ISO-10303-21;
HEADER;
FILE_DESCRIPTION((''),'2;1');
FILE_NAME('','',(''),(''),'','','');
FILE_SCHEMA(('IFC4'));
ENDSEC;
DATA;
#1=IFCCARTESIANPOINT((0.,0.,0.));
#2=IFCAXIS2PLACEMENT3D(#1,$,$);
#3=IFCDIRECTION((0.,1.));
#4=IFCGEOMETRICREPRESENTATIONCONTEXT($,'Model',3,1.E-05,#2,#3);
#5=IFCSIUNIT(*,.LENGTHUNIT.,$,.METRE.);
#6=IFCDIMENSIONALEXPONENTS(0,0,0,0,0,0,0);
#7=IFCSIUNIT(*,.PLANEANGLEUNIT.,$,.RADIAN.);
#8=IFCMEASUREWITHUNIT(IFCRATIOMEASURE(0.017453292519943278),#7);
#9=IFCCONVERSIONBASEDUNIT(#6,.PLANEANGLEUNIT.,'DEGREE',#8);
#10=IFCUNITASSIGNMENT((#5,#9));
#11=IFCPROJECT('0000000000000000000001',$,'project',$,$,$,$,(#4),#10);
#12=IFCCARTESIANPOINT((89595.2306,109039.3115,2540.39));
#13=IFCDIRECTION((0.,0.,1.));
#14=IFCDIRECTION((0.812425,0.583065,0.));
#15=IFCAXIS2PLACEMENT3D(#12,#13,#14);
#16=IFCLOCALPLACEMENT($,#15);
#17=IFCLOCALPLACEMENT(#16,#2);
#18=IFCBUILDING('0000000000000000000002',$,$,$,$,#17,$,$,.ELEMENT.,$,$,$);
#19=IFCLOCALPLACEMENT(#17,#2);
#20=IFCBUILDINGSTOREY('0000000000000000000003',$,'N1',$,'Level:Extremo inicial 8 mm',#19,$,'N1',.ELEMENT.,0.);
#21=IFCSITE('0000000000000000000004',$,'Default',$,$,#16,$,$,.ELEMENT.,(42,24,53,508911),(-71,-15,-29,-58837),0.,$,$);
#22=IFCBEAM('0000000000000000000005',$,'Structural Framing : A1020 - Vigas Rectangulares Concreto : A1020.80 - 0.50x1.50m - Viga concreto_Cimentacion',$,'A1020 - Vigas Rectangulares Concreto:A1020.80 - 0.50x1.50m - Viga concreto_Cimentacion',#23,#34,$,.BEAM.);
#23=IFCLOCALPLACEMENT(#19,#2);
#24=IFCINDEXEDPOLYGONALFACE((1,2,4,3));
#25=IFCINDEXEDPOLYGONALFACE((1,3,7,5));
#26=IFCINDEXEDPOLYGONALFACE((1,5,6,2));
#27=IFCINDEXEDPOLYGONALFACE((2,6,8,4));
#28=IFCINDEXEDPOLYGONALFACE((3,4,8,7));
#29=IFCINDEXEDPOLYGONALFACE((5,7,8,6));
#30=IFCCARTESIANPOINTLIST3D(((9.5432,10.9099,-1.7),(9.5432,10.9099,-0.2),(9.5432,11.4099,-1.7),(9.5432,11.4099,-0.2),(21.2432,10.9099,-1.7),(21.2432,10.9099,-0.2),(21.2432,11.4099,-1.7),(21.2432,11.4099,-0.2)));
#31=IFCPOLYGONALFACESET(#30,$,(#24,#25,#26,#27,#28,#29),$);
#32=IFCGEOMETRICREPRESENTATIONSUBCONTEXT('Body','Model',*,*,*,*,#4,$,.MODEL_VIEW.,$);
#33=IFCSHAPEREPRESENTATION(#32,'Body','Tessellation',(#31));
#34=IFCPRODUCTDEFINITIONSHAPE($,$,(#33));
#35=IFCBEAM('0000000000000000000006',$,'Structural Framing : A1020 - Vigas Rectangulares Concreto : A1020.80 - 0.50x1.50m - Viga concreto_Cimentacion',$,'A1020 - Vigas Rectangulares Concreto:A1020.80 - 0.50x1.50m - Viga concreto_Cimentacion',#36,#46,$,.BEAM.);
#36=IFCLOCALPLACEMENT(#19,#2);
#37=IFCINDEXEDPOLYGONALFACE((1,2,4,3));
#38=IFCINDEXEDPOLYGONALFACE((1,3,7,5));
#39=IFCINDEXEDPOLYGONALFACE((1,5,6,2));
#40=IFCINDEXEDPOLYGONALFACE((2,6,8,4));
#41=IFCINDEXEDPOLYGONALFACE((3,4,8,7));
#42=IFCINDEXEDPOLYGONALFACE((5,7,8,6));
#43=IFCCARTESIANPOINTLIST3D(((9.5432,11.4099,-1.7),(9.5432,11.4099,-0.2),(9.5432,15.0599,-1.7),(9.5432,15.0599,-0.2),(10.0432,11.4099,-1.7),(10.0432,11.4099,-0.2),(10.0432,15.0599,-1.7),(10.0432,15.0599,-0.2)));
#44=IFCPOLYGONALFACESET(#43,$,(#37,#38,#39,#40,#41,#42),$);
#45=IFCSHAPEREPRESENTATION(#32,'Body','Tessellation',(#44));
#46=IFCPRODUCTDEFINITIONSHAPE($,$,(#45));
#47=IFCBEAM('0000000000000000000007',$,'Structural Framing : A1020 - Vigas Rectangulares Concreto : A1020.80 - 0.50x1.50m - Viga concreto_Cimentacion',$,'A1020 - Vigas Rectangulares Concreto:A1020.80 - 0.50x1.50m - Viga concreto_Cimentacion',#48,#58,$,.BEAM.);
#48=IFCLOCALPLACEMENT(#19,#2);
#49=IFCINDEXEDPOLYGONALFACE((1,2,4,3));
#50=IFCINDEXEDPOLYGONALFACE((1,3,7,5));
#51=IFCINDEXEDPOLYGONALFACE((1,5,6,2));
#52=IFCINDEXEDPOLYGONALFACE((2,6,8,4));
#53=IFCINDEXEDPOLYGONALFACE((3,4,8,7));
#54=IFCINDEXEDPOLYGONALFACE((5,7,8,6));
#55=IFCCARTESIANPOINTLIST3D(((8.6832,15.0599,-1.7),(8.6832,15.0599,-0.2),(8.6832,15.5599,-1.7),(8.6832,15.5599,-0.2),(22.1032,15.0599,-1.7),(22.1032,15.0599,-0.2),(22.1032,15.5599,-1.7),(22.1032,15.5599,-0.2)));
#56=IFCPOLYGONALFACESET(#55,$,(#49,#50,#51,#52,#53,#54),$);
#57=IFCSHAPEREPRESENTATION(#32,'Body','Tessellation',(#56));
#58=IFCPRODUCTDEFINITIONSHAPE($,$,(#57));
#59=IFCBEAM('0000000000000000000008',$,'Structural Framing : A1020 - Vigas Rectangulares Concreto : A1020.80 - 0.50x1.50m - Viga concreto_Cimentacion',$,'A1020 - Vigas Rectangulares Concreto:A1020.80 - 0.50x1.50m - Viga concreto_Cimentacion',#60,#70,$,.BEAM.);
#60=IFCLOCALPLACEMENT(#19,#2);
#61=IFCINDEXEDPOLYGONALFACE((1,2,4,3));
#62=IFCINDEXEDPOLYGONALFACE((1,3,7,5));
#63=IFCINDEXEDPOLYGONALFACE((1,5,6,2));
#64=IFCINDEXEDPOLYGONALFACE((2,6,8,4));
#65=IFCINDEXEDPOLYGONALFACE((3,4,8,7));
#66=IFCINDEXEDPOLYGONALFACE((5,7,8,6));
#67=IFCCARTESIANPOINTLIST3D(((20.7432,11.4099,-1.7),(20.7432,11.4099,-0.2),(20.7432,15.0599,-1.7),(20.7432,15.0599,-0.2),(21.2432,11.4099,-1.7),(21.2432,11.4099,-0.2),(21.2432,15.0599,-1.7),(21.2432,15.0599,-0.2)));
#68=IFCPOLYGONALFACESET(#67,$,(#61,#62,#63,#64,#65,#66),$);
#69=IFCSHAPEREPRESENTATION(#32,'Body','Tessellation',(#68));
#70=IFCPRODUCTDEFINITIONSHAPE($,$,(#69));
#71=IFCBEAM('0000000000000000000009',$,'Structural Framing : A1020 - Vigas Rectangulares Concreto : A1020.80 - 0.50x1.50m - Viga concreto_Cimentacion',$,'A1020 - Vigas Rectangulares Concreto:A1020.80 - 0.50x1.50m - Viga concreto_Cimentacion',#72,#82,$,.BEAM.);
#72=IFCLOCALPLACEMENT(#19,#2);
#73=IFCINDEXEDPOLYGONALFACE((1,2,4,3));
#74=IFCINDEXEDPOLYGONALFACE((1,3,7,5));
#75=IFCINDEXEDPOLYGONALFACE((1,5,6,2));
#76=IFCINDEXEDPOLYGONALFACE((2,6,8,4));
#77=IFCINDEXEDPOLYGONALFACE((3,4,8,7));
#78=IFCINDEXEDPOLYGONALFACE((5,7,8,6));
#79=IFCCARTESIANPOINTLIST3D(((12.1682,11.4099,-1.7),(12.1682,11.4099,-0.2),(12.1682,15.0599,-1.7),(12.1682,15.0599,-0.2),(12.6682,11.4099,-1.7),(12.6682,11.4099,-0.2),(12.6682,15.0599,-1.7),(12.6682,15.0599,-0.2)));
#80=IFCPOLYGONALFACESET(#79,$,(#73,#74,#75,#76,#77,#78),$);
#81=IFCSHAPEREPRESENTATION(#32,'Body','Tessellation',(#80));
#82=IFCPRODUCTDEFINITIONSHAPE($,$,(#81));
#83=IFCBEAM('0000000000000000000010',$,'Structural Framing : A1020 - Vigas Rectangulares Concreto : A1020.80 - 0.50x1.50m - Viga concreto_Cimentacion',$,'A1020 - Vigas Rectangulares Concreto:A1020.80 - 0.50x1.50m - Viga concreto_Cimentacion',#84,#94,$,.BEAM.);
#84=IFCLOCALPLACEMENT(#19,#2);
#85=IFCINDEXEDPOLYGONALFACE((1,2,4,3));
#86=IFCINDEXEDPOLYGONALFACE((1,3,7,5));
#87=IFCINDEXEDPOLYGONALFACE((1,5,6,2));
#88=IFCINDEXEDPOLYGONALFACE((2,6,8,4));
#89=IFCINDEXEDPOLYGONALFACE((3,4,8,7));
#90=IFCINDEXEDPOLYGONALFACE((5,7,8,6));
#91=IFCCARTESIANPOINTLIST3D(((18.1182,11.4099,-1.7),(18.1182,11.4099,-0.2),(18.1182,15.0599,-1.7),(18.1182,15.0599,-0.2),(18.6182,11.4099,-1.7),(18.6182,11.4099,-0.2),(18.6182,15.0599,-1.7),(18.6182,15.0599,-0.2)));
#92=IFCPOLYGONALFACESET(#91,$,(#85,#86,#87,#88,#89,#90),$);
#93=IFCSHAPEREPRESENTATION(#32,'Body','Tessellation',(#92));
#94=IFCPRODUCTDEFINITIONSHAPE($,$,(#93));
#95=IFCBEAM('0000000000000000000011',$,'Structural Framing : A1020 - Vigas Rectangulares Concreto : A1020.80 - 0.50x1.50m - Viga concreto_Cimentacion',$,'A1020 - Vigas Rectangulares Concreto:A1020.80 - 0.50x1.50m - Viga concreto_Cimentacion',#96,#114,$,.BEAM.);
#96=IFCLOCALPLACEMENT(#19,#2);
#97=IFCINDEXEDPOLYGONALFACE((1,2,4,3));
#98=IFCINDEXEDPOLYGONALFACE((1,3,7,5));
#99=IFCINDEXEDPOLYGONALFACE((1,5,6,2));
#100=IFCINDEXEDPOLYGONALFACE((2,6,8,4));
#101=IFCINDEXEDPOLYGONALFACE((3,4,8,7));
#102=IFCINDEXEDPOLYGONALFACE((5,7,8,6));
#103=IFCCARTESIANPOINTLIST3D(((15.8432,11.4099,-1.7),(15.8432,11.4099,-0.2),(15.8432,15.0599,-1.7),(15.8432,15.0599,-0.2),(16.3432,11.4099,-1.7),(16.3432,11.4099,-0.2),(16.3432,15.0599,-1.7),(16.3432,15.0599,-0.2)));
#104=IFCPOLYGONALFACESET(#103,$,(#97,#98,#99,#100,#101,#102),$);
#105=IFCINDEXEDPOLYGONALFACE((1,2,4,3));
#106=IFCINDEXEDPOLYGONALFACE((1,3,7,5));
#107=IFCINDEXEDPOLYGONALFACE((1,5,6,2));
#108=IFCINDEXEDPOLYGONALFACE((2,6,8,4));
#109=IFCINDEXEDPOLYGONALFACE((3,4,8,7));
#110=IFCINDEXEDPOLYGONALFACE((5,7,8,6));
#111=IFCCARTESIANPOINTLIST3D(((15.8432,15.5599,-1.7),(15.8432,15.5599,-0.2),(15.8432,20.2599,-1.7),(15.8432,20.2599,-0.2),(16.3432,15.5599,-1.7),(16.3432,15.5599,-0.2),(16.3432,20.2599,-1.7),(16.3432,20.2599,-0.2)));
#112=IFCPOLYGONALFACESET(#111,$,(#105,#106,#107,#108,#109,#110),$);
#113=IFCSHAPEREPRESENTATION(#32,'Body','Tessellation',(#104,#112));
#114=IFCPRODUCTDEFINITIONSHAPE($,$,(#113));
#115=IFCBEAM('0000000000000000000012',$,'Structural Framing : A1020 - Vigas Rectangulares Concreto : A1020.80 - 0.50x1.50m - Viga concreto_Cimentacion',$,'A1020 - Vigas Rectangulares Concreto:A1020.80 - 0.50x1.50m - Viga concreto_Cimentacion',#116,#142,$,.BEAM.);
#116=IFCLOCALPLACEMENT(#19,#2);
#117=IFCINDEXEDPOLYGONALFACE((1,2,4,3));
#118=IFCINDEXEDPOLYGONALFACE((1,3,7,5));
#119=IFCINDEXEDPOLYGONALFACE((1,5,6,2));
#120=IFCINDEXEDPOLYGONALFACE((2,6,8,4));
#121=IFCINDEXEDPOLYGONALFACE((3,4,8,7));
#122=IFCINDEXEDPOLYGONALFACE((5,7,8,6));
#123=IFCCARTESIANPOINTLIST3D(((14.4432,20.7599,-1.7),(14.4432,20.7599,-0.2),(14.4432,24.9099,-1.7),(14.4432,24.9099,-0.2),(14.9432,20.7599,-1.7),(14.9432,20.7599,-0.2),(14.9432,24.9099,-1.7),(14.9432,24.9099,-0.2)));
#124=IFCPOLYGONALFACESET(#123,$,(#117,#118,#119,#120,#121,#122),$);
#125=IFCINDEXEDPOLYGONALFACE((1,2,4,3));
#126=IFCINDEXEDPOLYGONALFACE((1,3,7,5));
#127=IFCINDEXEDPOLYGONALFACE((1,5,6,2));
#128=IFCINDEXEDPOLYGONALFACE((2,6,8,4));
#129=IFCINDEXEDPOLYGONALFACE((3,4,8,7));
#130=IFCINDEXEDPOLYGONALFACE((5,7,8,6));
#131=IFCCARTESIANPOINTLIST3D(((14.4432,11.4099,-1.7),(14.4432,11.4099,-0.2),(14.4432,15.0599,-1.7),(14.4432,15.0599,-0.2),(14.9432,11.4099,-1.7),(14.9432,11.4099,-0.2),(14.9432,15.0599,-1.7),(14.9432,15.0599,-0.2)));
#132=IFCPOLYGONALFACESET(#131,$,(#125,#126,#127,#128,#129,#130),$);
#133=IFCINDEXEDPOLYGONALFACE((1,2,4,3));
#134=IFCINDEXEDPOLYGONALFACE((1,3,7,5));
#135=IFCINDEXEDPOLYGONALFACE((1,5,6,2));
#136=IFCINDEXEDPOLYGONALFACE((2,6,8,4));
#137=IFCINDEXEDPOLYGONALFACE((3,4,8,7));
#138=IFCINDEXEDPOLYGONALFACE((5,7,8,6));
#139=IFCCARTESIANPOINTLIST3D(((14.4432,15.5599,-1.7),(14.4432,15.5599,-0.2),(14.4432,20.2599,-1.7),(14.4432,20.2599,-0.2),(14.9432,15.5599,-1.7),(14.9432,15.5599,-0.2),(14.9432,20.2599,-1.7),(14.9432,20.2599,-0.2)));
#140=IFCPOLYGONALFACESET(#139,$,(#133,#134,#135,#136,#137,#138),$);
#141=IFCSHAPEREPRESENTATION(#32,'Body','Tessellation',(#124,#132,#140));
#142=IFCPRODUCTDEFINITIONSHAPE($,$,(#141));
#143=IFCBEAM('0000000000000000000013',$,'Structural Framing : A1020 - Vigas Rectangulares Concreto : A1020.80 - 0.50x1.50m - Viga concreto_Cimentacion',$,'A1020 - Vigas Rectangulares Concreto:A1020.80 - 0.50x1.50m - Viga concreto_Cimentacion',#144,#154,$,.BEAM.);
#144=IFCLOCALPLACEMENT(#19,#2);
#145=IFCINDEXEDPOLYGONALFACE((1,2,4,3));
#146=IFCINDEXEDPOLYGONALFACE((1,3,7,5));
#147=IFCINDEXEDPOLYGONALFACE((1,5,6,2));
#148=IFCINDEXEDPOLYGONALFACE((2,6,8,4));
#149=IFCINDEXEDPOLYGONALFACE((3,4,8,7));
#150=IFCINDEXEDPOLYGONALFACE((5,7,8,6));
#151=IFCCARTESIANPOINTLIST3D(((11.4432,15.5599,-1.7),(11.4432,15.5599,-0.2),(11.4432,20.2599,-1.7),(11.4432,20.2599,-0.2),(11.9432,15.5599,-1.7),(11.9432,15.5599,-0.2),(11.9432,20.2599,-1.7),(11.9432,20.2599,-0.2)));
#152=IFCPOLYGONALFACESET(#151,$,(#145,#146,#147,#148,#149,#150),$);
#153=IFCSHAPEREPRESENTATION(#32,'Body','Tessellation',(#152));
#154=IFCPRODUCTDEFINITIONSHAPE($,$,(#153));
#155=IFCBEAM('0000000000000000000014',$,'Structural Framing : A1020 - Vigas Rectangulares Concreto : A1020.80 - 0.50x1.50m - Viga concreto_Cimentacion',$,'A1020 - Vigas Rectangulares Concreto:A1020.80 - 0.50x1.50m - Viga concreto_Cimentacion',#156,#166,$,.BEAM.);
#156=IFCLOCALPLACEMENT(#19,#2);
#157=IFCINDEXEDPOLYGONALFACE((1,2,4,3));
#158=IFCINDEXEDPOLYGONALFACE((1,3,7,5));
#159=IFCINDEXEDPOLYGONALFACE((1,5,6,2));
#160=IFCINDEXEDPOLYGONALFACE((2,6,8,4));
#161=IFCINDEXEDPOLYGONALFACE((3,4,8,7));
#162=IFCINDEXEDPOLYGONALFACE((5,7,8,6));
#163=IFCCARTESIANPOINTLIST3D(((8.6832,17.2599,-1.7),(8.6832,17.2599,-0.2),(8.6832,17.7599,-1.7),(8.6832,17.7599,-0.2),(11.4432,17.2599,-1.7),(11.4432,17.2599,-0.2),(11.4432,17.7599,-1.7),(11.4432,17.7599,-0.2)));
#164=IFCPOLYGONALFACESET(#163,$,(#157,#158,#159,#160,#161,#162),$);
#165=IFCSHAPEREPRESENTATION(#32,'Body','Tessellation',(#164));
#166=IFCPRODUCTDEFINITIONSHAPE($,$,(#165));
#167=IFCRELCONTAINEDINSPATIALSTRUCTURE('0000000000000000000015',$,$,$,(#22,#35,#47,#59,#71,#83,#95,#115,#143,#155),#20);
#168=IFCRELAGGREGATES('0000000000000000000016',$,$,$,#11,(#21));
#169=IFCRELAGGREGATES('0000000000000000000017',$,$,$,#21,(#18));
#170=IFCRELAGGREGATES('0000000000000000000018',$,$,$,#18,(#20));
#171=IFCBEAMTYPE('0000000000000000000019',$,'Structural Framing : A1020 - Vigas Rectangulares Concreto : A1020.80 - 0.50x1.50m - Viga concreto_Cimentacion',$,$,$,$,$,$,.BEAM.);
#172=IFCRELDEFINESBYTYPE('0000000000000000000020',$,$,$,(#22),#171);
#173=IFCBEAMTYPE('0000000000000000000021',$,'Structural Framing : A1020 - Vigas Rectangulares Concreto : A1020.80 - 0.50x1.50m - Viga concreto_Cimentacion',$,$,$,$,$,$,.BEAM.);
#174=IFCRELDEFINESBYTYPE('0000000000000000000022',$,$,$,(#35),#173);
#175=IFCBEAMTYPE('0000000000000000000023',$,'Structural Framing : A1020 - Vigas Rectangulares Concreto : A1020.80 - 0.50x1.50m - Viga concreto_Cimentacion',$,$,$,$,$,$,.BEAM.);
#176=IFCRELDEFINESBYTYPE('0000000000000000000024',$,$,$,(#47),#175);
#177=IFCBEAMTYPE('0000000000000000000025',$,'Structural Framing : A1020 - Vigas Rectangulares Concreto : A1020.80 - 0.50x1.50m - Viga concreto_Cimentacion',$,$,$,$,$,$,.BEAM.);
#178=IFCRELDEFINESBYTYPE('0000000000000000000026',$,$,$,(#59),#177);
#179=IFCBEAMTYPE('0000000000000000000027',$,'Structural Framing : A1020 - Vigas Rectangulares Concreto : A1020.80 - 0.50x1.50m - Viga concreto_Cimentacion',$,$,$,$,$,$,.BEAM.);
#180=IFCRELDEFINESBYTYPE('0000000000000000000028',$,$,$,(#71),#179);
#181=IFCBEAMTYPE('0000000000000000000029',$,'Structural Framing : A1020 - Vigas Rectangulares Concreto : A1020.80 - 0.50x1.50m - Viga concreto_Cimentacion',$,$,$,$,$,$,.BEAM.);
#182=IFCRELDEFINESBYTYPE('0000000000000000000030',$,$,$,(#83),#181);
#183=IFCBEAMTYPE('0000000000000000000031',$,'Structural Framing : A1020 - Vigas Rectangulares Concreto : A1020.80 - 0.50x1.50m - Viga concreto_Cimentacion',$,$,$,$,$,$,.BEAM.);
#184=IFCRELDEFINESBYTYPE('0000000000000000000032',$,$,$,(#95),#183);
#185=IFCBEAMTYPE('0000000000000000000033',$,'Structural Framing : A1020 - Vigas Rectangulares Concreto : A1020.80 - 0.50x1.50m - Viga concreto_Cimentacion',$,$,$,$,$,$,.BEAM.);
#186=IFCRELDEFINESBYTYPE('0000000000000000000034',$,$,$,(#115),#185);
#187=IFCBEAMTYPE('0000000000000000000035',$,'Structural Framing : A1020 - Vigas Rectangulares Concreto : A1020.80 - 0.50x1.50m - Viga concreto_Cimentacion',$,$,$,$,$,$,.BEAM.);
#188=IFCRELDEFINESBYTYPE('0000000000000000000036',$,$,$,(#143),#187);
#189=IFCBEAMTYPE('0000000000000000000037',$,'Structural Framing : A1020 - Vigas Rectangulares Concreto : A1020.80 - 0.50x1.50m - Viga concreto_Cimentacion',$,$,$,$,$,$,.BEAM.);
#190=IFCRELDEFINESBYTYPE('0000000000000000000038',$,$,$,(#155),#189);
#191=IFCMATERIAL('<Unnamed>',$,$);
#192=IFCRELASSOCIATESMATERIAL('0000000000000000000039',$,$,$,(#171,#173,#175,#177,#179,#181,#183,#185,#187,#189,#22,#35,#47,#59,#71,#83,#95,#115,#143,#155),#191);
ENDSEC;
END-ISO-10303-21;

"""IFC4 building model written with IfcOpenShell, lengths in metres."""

from ifc_helpers import new_model, entity, si_unit, converted_unit, direction, frame, frame_2d, origin, place, context, subcontext, project, spatial, polyline, segment, composite_curve, rectangle, outline, extrude, source, transform, mapped, material, material_profile, profile_set, profile_usage, type_object, type_shapes, element, save


model = new_model("IFC4")

# Units and contexts
model_context = context("Model", 3, precision=1e-05, world=origin(), true_north=direction((0.0, 1.0)))
body_context = subcontext(model_context, "Body", "Model", "MODEL_VIEW")
ifc_project = project(units=[si_unit("LENGTHUNIT", "METRE"), converted_unit("PLANEANGLEUNIT", "DEGREE", entity("IfcRatioMeasure", 0.017453292519943278), si_unit("PLANEANGLEUNIT", "RADIAN"), dimensions=[0, 0, 0, 0, 0, 0, 0])], contexts=[model_context])

# Site, building, storey
site_placement = place(None, frame((89595.2306, 109039.3115, 2540.39), z_axis=(0.0, 0.0, 1.0), x_axis=(0.812425, 0.583065, 0.0)))
site = spatial("IfcSite", under=ifc_project, at=site_placement, Name="Default", CompositionType="ELEMENT", RefLatitude=(42, 24, 53, 508911), RefLongitude=(-71, -15, -29, -58837), RefElevation=0.0)
building_placement = place(site_placement, origin())
building = spatial("IfcBuilding", under=site, at=building_placement, CompositionType="ELEMENT")
storey_placement = place(building_placement, origin())
storey = spatial("IfcBuildingStorey", under=building, at=storey_placement, Name="N1", ObjectType="Level:Extremo inicial 8 mm", LongName="N1", CompositionType="ELEMENT", Elevation=0.0)

# Beams
ifc_material_1 = material(Name="<Unnamed>")
ifc_material_profile_1 = material_profile(ifc_material_1, outline(composite_curve([segment(polyline([(0.25, 0.75, 0.0), (0.25, -0.75, 0.0)]), True, "CONTINUOUS"), segment(polyline([(0.25, -0.75, 0.0), (-0.25, -0.75, 0.0)]), True, "CONTINUOUS"), segment(polyline([(-0.25, -0.75, 0.0), (-0.25, 0.75, 0.0)]), True, "CONTINUOUS"), segment(polyline([(-0.25, 0.75, 0.0), (0.25, 0.75, 0.0)]), True, "CONTINUOUS")], self_intersect=False), kind="CURVE"), Name="A1020.80 - 0.50x1.50m - Viga concreto_Cimentacion")
ifc_material_profile_2 = material_profile(ifc_material_1, outline(composite_curve([segment(polyline([(-5.3373, 0.25, 0.75), (-5.3373, 0.25, -0.75)]), True, "CONTINUOUS"), segment(polyline([(-5.3373, 0.25, -0.75), (-5.3373, -0.25, -0.75)]), True, "CONTINUOUS"), segment(polyline([(-5.3373, -0.25, -0.75), (-5.3373, -0.25, 0.75)]), True, "CONTINUOUS"), segment(polyline([(-5.3373, -0.25, 0.75), (-5.3373, 0.25, 0.75)]), True, "CONTINUOUS")], self_intersect=False), kind="CURVE"), Name="A1020.80 - 0.50x1.50m - Viga concreto_Cimentacion")
ifc_profile_set_1 = profile_set([ifc_material_profile_1, ifc_material_profile_2], Name="A1020.80 - 0.50x1.50m - Viga concreto_Cimentacion")
ifc_profile_usage_1 = profile_usage(ifc_profile_set_1, cardinal=8)
beam_type_1 = type_object("IfcBeamType", Name="Structural Framing : A1020 - Vigas Rectangulares Concreto : A1020.80 - 0.50x1.50m - Viga concreto_Cimentacion", PredefinedType="BEAM", material=ifc_profile_set_1)
shared_shape_1 = source(origin(), body_context, "Body", "SweptSolid", [
    extrude(rectangle(XDim=1.5, YDim=0.5, at=frame_2d((0.0, 0.0), x_axis=(1.0, 0.0))), frame((9.5432, 11.1599, -0.95), z_axis=(1.0, 0.0, 0.0), x_axis=(0.0, 0.0, -1.0)), (0.0, 0.0, 1.0), 11.7),
])
type_shapes(beam_type_1, [shared_shape_1])
beam_1_placement = place(storey_placement, origin())
element("IfcBeam", 1, at=beam_1_placement, inside=storey, type_object=beam_type_1, material=ifc_profile_usage_1, Name="Structural Framing : A1020 - Vigas Rectangulares Concreto : A1020.80 - 0.50x1.50m - Viga concreto_Cimentacion", ObjectType="A1020 - Vigas Rectangulares Concreto:A1020.80 - 0.50x1.50m - Viga concreto_Cimentacion", PredefinedType="BEAM", context=body_context, shape_type="MappedRepresentation", body=[
    mapped(shared_shape_1, transform((0.0, 0.0, 0.0), scale=1.0)),
])
ifc_profile_usage_2 = profile_usage(ifc_profile_set_1, cardinal=8)
beam_type_2 = type_object("IfcBeamType", Name="Structural Framing : A1020 - Vigas Rectangulares Concreto : A1020.80 - 0.50x1.50m - Viga concreto_Cimentacion", PredefinedType="BEAM", material=ifc_profile_set_1)
shared_shape_2 = source(origin(), body_context, "Body", "SweptSolid", [
    extrude(rectangle(XDim=1.5, YDim=0.5, at=frame_2d((0.0, 0.0), x_axis=(0.0, 1.0))), frame((9.7932, 11.4099, -0.95), z_axis=(0.0, 1.0, 0.0), x_axis=(-1.0, 0.0, 0.0)), (0.0, 0.0, 1.0), 3.65),
])
type_shapes(beam_type_2, [shared_shape_2])
beam_2_placement = place(storey_placement, origin())
element("IfcBeam", 2, at=beam_2_placement, inside=storey, type_object=beam_type_2, material=ifc_profile_usage_2, Name="Structural Framing : A1020 - Vigas Rectangulares Concreto : A1020.80 - 0.50x1.50m - Viga concreto_Cimentacion", ObjectType="A1020 - Vigas Rectangulares Concreto:A1020.80 - 0.50x1.50m - Viga concreto_Cimentacion", PredefinedType="BEAM", context=body_context, shape_type="MappedRepresentation", body=[
    mapped(shared_shape_2, transform((0.0, 0.0, 0.0), scale=1.0)),
])
ifc_profile_usage_3 = profile_usage(ifc_profile_set_1, cardinal=8)
beam_type_3 = type_object("IfcBeamType", Name="Structural Framing : A1020 - Vigas Rectangulares Concreto : A1020.80 - 0.50x1.50m - Viga concreto_Cimentacion", PredefinedType="BEAM", material=ifc_profile_set_1)
shared_shape_3 = source(origin(), body_context, "Body", "SweptSolid", [
    extrude(rectangle(XDim=1.5, YDim=0.5, at=frame_2d((0.0, 0.0), x_axis=(1.0, 0.0))), frame((22.1032, 15.3099, -0.95), z_axis=(-1.0, 0.0, 0.0), x_axis=(0.0, 0.0, -1.0)), (0.0, 0.0, 1.0), 13.42),
])
type_shapes(beam_type_3, [shared_shape_3])
beam_3_placement = place(storey_placement, origin())
element("IfcBeam", 3, at=beam_3_placement, inside=storey, type_object=beam_type_3, material=ifc_profile_usage_3, Name="Structural Framing : A1020 - Vigas Rectangulares Concreto : A1020.80 - 0.50x1.50m - Viga concreto_Cimentacion", ObjectType="A1020 - Vigas Rectangulares Concreto:A1020.80 - 0.50x1.50m - Viga concreto_Cimentacion", PredefinedType="BEAM", context=body_context, shape_type="MappedRepresentation", body=[
    mapped(shared_shape_3, transform((0.0, 0.0, 0.0), scale=1.0)),
])
ifc_profile_usage_4 = profile_usage(ifc_profile_set_1, cardinal=8)
beam_type_4 = type_object("IfcBeamType", Name="Structural Framing : A1020 - Vigas Rectangulares Concreto : A1020.80 - 0.50x1.50m - Viga concreto_Cimentacion", PredefinedType="BEAM", material=ifc_profile_set_1)
shared_shape_4 = source(origin(), body_context, "Body", "SweptSolid", [
    extrude(rectangle(XDim=1.5, YDim=0.5, at=frame_2d((0.0, 0.0), x_axis=(0.0, 1.0))), frame((20.9932, 11.4099, -0.95), z_axis=(0.0, 1.0, 0.0), x_axis=(-1.0, 0.0, 0.0)), (0.0, 0.0, 1.0), 3.65),
])
type_shapes(beam_type_4, [shared_shape_4])
beam_4_placement = place(storey_placement, origin())
element("IfcBeam", 4, at=beam_4_placement, inside=storey, type_object=beam_type_4, material=ifc_profile_usage_4, Name="Structural Framing : A1020 - Vigas Rectangulares Concreto : A1020.80 - 0.50x1.50m - Viga concreto_Cimentacion", ObjectType="A1020 - Vigas Rectangulares Concreto:A1020.80 - 0.50x1.50m - Viga concreto_Cimentacion", PredefinedType="BEAM", context=body_context, shape_type="MappedRepresentation", body=[
    mapped(shared_shape_4, transform((0.0, 0.0, 0.0), scale=1.0)),
])
ifc_profile_usage_5 = profile_usage(ifc_profile_set_1, cardinal=8)
beam_type_5 = type_object("IfcBeamType", Name="Structural Framing : A1020 - Vigas Rectangulares Concreto : A1020.80 - 0.50x1.50m - Viga concreto_Cimentacion", PredefinedType="BEAM", material=ifc_profile_set_1)
shared_shape_5 = source(origin(), body_context, "Body", "SweptSolid", [
    extrude(rectangle(XDim=1.5, YDim=0.5, at=frame_2d((0.0, 0.0), x_axis=(0.0, 1.0))), frame((12.4182, 11.4099, -0.95), z_axis=(0.0, 1.0, 0.0), x_axis=(-1.0, 0.0, 0.0)), (0.0, 0.0, 1.0), 3.65),
])
type_shapes(beam_type_5, [shared_shape_5])
beam_5_placement = place(storey_placement, origin())
element("IfcBeam", 5, at=beam_5_placement, inside=storey, type_object=beam_type_5, material=ifc_profile_usage_5, Name="Structural Framing : A1020 - Vigas Rectangulares Concreto : A1020.80 - 0.50x1.50m - Viga concreto_Cimentacion", ObjectType="A1020 - Vigas Rectangulares Concreto:A1020.80 - 0.50x1.50m - Viga concreto_Cimentacion", PredefinedType="BEAM", context=body_context, shape_type="MappedRepresentation", body=[
    mapped(shared_shape_5, transform((0.0, 0.0, 0.0), scale=1.0)),
])
ifc_profile_usage_6 = profile_usage(ifc_profile_set_1, cardinal=8)
beam_type_6 = type_object("IfcBeamType", Name="Structural Framing : A1020 - Vigas Rectangulares Concreto : A1020.80 - 0.50x1.50m - Viga concreto_Cimentacion", PredefinedType="BEAM", material=ifc_profile_set_1)
shared_shape_6 = source(origin(), body_context, "Body", "SweptSolid", [
    extrude(rectangle(XDim=1.5, YDim=0.5, at=frame_2d((0.0, 0.0), x_axis=(0.0, 1.0))), frame((18.3682, 11.4099, -0.95), z_axis=(0.0, 1.0, 0.0), x_axis=(-1.0, 0.0, 0.0)), (0.0, 0.0, 1.0), 3.65),
])
type_shapes(beam_type_6, [shared_shape_6])
beam_6_placement = place(storey_placement, origin())
element("IfcBeam", 6, at=beam_6_placement, inside=storey, type_object=beam_type_6, material=ifc_profile_usage_6, Name="Structural Framing : A1020 - Vigas Rectangulares Concreto : A1020.80 - 0.50x1.50m - Viga concreto_Cimentacion", ObjectType="A1020 - Vigas Rectangulares Concreto:A1020.80 - 0.50x1.50m - Viga concreto_Cimentacion", PredefinedType="BEAM", context=body_context, shape_type="MappedRepresentation", body=[
    mapped(shared_shape_6, transform((0.0, 0.0, 0.0), scale=1.0)),
])
ifc_profile_usage_7 = profile_usage(ifc_profile_set_1, cardinal=8)
beam_type_7 = type_object("IfcBeamType", Name="Structural Framing : A1020 - Vigas Rectangulares Concreto : A1020.80 - 0.50x1.50m - Viga concreto_Cimentacion", PredefinedType="BEAM", material=ifc_profile_set_1)
shared_shape_7 = source(origin(), body_context, "Body", "SweptSolid", [
    extrude(rectangle(XDim=1.5, YDim=0.5, at=frame_2d((0.0, 0.0), x_axis=(0.0, 1.0))), frame((16.0932, 11.4099, -0.95), z_axis=(0.0, 1.0, 0.0), x_axis=(-1.0, 0.0, 0.0)), (0.0, 0.0, 1.0), 3.65),
    extrude(rectangle(XDim=1.5, YDim=0.5, at=frame_2d((0.0, 0.0), x_axis=(0.0, 1.0))), frame((16.0932, 15.5599, -0.95), z_axis=(0.0, 1.0, 0.0), x_axis=(-1.0, 0.0, 0.0)), (0.0, 0.0, 1.0), 4.7),
])
type_shapes(beam_type_7, [shared_shape_7])
beam_7_placement = place(storey_placement, origin())
element("IfcBeam", 7, at=beam_7_placement, inside=storey, type_object=beam_type_7, material=ifc_profile_usage_7, Name="Structural Framing : A1020 - Vigas Rectangulares Concreto : A1020.80 - 0.50x1.50m - Viga concreto_Cimentacion", ObjectType="A1020 - Vigas Rectangulares Concreto:A1020.80 - 0.50x1.50m - Viga concreto_Cimentacion", PredefinedType="BEAM", context=body_context, shape_type="MappedRepresentation", body=[
    mapped(shared_shape_7, transform((0.0, 0.0, 0.0), scale=1.0)),
])
ifc_profile_usage_8 = profile_usage(ifc_profile_set_1, cardinal=8)
beam_type_8 = type_object("IfcBeamType", Name="Structural Framing : A1020 - Vigas Rectangulares Concreto : A1020.80 - 0.50x1.50m - Viga concreto_Cimentacion", PredefinedType="BEAM", material=ifc_profile_set_1)
shared_shape_8 = source(origin(), body_context, "Body", "SweptSolid", [
    extrude(rectangle(XDim=1.5, YDim=0.5, at=frame_2d((0.0, 0.0), x_axis=(0.0, 1.0))), frame((14.6932, 20.7599, -0.95), z_axis=(0.0, 1.0, 0.0), x_axis=(-1.0, 0.0, 0.0)), (0.0, 0.0, 1.0), 4.15),
    extrude(rectangle(XDim=1.5, YDim=0.5, at=frame_2d((0.0, 0.0), x_axis=(0.0, 1.0))), frame((14.6932, 11.4099, -0.95), z_axis=(0.0, 1.0, 0.0), x_axis=(-1.0, 0.0, 0.0)), (0.0, 0.0, 1.0), 3.65),
    extrude(rectangle(XDim=1.5, YDim=0.5, at=frame_2d((0.0, 0.0), x_axis=(0.0, 1.0))), frame((14.6932, 15.5599, -0.95), z_axis=(0.0, 1.0, 0.0), x_axis=(-1.0, 0.0, 0.0)), (0.0, 0.0, 1.0), 4.7),
])
type_shapes(beam_type_8, [shared_shape_8])
beam_8_placement = place(storey_placement, origin())
element("IfcBeam", 8, at=beam_8_placement, inside=storey, type_object=beam_type_8, material=ifc_profile_usage_8, Name="Structural Framing : A1020 - Vigas Rectangulares Concreto : A1020.80 - 0.50x1.50m - Viga concreto_Cimentacion", ObjectType="A1020 - Vigas Rectangulares Concreto:A1020.80 - 0.50x1.50m - Viga concreto_Cimentacion", PredefinedType="BEAM", context=body_context, shape_type="MappedRepresentation", body=[
    mapped(shared_shape_8, transform((0.0, 0.0, 0.0), scale=1.0)),
])
ifc_profile_usage_9 = profile_usage(ifc_profile_set_1, cardinal=8)
beam_type_9 = type_object("IfcBeamType", Name="Structural Framing : A1020 - Vigas Rectangulares Concreto : A1020.80 - 0.50x1.50m - Viga concreto_Cimentacion", PredefinedType="BEAM", material=ifc_profile_set_1)
shared_shape_9 = source(origin(), body_context, "Body", "SweptSolid", [
    extrude(rectangle(XDim=1.5, YDim=0.5, at=frame_2d((0.0, 0.0), x_axis=(0.0, 1.0))), frame((11.6932, 20.2599, -0.95), z_axis=(0.0, -1.0, 0.0), x_axis=(-1.0, 0.0, 0.0)), (0.0, 0.0, 1.0), 4.7),
])
type_shapes(beam_type_9, [shared_shape_9])
beam_9_placement = place(storey_placement, origin())
element("IfcBeam", 9, at=beam_9_placement, inside=storey, type_object=beam_type_9, material=ifc_profile_usage_9, Name="Structural Framing : A1020 - Vigas Rectangulares Concreto : A1020.80 - 0.50x1.50m - Viga concreto_Cimentacion", ObjectType="A1020 - Vigas Rectangulares Concreto:A1020.80 - 0.50x1.50m - Viga concreto_Cimentacion", PredefinedType="BEAM", context=body_context, shape_type="MappedRepresentation", body=[
    mapped(shared_shape_9, transform((0.0, 0.0, 0.0), scale=1.0)),
])
ifc_profile_usage_10 = profile_usage(ifc_profile_set_1, cardinal=8)
beam_type_10 = type_object("IfcBeamType", Name="Structural Framing : A1020 - Vigas Rectangulares Concreto : A1020.80 - 0.50x1.50m - Viga concreto_Cimentacion", PredefinedType="BEAM", material=ifc_profile_set_1)
shared_shape_10 = source(origin(), body_context, "Body", "SweptSolid", [
    extrude(rectangle(XDim=1.5, YDim=0.5, at=frame_2d((0.0, 0.0), x_axis=(1.0, 0.0))), frame((11.4432, 17.5099, -0.95), z_axis=(-1.0, 0.0, 0.0), x_axis=(0.0, 0.0, -1.0)), (0.0, 0.0, 1.0), 2.76),
])
type_shapes(beam_type_10, [shared_shape_10])
beam_10_placement = place(storey_placement, origin())
element("IfcBeam", 10, at=beam_10_placement, inside=storey, type_object=beam_type_10, material=ifc_profile_usage_10, Name="Structural Framing : A1020 - Vigas Rectangulares Concreto : A1020.80 - 0.50x1.50m - Viga concreto_Cimentacion", ObjectType="A1020 - Vigas Rectangulares Concreto:A1020.80 - 0.50x1.50m - Viga concreto_Cimentacion", PredefinedType="BEAM", context=body_context, shape_type="MappedRepresentation", body=[
    mapped(shared_shape_10, transform((0.0, 0.0, 0.0), scale=1.0)),
])

save(model, "model.ifc")
